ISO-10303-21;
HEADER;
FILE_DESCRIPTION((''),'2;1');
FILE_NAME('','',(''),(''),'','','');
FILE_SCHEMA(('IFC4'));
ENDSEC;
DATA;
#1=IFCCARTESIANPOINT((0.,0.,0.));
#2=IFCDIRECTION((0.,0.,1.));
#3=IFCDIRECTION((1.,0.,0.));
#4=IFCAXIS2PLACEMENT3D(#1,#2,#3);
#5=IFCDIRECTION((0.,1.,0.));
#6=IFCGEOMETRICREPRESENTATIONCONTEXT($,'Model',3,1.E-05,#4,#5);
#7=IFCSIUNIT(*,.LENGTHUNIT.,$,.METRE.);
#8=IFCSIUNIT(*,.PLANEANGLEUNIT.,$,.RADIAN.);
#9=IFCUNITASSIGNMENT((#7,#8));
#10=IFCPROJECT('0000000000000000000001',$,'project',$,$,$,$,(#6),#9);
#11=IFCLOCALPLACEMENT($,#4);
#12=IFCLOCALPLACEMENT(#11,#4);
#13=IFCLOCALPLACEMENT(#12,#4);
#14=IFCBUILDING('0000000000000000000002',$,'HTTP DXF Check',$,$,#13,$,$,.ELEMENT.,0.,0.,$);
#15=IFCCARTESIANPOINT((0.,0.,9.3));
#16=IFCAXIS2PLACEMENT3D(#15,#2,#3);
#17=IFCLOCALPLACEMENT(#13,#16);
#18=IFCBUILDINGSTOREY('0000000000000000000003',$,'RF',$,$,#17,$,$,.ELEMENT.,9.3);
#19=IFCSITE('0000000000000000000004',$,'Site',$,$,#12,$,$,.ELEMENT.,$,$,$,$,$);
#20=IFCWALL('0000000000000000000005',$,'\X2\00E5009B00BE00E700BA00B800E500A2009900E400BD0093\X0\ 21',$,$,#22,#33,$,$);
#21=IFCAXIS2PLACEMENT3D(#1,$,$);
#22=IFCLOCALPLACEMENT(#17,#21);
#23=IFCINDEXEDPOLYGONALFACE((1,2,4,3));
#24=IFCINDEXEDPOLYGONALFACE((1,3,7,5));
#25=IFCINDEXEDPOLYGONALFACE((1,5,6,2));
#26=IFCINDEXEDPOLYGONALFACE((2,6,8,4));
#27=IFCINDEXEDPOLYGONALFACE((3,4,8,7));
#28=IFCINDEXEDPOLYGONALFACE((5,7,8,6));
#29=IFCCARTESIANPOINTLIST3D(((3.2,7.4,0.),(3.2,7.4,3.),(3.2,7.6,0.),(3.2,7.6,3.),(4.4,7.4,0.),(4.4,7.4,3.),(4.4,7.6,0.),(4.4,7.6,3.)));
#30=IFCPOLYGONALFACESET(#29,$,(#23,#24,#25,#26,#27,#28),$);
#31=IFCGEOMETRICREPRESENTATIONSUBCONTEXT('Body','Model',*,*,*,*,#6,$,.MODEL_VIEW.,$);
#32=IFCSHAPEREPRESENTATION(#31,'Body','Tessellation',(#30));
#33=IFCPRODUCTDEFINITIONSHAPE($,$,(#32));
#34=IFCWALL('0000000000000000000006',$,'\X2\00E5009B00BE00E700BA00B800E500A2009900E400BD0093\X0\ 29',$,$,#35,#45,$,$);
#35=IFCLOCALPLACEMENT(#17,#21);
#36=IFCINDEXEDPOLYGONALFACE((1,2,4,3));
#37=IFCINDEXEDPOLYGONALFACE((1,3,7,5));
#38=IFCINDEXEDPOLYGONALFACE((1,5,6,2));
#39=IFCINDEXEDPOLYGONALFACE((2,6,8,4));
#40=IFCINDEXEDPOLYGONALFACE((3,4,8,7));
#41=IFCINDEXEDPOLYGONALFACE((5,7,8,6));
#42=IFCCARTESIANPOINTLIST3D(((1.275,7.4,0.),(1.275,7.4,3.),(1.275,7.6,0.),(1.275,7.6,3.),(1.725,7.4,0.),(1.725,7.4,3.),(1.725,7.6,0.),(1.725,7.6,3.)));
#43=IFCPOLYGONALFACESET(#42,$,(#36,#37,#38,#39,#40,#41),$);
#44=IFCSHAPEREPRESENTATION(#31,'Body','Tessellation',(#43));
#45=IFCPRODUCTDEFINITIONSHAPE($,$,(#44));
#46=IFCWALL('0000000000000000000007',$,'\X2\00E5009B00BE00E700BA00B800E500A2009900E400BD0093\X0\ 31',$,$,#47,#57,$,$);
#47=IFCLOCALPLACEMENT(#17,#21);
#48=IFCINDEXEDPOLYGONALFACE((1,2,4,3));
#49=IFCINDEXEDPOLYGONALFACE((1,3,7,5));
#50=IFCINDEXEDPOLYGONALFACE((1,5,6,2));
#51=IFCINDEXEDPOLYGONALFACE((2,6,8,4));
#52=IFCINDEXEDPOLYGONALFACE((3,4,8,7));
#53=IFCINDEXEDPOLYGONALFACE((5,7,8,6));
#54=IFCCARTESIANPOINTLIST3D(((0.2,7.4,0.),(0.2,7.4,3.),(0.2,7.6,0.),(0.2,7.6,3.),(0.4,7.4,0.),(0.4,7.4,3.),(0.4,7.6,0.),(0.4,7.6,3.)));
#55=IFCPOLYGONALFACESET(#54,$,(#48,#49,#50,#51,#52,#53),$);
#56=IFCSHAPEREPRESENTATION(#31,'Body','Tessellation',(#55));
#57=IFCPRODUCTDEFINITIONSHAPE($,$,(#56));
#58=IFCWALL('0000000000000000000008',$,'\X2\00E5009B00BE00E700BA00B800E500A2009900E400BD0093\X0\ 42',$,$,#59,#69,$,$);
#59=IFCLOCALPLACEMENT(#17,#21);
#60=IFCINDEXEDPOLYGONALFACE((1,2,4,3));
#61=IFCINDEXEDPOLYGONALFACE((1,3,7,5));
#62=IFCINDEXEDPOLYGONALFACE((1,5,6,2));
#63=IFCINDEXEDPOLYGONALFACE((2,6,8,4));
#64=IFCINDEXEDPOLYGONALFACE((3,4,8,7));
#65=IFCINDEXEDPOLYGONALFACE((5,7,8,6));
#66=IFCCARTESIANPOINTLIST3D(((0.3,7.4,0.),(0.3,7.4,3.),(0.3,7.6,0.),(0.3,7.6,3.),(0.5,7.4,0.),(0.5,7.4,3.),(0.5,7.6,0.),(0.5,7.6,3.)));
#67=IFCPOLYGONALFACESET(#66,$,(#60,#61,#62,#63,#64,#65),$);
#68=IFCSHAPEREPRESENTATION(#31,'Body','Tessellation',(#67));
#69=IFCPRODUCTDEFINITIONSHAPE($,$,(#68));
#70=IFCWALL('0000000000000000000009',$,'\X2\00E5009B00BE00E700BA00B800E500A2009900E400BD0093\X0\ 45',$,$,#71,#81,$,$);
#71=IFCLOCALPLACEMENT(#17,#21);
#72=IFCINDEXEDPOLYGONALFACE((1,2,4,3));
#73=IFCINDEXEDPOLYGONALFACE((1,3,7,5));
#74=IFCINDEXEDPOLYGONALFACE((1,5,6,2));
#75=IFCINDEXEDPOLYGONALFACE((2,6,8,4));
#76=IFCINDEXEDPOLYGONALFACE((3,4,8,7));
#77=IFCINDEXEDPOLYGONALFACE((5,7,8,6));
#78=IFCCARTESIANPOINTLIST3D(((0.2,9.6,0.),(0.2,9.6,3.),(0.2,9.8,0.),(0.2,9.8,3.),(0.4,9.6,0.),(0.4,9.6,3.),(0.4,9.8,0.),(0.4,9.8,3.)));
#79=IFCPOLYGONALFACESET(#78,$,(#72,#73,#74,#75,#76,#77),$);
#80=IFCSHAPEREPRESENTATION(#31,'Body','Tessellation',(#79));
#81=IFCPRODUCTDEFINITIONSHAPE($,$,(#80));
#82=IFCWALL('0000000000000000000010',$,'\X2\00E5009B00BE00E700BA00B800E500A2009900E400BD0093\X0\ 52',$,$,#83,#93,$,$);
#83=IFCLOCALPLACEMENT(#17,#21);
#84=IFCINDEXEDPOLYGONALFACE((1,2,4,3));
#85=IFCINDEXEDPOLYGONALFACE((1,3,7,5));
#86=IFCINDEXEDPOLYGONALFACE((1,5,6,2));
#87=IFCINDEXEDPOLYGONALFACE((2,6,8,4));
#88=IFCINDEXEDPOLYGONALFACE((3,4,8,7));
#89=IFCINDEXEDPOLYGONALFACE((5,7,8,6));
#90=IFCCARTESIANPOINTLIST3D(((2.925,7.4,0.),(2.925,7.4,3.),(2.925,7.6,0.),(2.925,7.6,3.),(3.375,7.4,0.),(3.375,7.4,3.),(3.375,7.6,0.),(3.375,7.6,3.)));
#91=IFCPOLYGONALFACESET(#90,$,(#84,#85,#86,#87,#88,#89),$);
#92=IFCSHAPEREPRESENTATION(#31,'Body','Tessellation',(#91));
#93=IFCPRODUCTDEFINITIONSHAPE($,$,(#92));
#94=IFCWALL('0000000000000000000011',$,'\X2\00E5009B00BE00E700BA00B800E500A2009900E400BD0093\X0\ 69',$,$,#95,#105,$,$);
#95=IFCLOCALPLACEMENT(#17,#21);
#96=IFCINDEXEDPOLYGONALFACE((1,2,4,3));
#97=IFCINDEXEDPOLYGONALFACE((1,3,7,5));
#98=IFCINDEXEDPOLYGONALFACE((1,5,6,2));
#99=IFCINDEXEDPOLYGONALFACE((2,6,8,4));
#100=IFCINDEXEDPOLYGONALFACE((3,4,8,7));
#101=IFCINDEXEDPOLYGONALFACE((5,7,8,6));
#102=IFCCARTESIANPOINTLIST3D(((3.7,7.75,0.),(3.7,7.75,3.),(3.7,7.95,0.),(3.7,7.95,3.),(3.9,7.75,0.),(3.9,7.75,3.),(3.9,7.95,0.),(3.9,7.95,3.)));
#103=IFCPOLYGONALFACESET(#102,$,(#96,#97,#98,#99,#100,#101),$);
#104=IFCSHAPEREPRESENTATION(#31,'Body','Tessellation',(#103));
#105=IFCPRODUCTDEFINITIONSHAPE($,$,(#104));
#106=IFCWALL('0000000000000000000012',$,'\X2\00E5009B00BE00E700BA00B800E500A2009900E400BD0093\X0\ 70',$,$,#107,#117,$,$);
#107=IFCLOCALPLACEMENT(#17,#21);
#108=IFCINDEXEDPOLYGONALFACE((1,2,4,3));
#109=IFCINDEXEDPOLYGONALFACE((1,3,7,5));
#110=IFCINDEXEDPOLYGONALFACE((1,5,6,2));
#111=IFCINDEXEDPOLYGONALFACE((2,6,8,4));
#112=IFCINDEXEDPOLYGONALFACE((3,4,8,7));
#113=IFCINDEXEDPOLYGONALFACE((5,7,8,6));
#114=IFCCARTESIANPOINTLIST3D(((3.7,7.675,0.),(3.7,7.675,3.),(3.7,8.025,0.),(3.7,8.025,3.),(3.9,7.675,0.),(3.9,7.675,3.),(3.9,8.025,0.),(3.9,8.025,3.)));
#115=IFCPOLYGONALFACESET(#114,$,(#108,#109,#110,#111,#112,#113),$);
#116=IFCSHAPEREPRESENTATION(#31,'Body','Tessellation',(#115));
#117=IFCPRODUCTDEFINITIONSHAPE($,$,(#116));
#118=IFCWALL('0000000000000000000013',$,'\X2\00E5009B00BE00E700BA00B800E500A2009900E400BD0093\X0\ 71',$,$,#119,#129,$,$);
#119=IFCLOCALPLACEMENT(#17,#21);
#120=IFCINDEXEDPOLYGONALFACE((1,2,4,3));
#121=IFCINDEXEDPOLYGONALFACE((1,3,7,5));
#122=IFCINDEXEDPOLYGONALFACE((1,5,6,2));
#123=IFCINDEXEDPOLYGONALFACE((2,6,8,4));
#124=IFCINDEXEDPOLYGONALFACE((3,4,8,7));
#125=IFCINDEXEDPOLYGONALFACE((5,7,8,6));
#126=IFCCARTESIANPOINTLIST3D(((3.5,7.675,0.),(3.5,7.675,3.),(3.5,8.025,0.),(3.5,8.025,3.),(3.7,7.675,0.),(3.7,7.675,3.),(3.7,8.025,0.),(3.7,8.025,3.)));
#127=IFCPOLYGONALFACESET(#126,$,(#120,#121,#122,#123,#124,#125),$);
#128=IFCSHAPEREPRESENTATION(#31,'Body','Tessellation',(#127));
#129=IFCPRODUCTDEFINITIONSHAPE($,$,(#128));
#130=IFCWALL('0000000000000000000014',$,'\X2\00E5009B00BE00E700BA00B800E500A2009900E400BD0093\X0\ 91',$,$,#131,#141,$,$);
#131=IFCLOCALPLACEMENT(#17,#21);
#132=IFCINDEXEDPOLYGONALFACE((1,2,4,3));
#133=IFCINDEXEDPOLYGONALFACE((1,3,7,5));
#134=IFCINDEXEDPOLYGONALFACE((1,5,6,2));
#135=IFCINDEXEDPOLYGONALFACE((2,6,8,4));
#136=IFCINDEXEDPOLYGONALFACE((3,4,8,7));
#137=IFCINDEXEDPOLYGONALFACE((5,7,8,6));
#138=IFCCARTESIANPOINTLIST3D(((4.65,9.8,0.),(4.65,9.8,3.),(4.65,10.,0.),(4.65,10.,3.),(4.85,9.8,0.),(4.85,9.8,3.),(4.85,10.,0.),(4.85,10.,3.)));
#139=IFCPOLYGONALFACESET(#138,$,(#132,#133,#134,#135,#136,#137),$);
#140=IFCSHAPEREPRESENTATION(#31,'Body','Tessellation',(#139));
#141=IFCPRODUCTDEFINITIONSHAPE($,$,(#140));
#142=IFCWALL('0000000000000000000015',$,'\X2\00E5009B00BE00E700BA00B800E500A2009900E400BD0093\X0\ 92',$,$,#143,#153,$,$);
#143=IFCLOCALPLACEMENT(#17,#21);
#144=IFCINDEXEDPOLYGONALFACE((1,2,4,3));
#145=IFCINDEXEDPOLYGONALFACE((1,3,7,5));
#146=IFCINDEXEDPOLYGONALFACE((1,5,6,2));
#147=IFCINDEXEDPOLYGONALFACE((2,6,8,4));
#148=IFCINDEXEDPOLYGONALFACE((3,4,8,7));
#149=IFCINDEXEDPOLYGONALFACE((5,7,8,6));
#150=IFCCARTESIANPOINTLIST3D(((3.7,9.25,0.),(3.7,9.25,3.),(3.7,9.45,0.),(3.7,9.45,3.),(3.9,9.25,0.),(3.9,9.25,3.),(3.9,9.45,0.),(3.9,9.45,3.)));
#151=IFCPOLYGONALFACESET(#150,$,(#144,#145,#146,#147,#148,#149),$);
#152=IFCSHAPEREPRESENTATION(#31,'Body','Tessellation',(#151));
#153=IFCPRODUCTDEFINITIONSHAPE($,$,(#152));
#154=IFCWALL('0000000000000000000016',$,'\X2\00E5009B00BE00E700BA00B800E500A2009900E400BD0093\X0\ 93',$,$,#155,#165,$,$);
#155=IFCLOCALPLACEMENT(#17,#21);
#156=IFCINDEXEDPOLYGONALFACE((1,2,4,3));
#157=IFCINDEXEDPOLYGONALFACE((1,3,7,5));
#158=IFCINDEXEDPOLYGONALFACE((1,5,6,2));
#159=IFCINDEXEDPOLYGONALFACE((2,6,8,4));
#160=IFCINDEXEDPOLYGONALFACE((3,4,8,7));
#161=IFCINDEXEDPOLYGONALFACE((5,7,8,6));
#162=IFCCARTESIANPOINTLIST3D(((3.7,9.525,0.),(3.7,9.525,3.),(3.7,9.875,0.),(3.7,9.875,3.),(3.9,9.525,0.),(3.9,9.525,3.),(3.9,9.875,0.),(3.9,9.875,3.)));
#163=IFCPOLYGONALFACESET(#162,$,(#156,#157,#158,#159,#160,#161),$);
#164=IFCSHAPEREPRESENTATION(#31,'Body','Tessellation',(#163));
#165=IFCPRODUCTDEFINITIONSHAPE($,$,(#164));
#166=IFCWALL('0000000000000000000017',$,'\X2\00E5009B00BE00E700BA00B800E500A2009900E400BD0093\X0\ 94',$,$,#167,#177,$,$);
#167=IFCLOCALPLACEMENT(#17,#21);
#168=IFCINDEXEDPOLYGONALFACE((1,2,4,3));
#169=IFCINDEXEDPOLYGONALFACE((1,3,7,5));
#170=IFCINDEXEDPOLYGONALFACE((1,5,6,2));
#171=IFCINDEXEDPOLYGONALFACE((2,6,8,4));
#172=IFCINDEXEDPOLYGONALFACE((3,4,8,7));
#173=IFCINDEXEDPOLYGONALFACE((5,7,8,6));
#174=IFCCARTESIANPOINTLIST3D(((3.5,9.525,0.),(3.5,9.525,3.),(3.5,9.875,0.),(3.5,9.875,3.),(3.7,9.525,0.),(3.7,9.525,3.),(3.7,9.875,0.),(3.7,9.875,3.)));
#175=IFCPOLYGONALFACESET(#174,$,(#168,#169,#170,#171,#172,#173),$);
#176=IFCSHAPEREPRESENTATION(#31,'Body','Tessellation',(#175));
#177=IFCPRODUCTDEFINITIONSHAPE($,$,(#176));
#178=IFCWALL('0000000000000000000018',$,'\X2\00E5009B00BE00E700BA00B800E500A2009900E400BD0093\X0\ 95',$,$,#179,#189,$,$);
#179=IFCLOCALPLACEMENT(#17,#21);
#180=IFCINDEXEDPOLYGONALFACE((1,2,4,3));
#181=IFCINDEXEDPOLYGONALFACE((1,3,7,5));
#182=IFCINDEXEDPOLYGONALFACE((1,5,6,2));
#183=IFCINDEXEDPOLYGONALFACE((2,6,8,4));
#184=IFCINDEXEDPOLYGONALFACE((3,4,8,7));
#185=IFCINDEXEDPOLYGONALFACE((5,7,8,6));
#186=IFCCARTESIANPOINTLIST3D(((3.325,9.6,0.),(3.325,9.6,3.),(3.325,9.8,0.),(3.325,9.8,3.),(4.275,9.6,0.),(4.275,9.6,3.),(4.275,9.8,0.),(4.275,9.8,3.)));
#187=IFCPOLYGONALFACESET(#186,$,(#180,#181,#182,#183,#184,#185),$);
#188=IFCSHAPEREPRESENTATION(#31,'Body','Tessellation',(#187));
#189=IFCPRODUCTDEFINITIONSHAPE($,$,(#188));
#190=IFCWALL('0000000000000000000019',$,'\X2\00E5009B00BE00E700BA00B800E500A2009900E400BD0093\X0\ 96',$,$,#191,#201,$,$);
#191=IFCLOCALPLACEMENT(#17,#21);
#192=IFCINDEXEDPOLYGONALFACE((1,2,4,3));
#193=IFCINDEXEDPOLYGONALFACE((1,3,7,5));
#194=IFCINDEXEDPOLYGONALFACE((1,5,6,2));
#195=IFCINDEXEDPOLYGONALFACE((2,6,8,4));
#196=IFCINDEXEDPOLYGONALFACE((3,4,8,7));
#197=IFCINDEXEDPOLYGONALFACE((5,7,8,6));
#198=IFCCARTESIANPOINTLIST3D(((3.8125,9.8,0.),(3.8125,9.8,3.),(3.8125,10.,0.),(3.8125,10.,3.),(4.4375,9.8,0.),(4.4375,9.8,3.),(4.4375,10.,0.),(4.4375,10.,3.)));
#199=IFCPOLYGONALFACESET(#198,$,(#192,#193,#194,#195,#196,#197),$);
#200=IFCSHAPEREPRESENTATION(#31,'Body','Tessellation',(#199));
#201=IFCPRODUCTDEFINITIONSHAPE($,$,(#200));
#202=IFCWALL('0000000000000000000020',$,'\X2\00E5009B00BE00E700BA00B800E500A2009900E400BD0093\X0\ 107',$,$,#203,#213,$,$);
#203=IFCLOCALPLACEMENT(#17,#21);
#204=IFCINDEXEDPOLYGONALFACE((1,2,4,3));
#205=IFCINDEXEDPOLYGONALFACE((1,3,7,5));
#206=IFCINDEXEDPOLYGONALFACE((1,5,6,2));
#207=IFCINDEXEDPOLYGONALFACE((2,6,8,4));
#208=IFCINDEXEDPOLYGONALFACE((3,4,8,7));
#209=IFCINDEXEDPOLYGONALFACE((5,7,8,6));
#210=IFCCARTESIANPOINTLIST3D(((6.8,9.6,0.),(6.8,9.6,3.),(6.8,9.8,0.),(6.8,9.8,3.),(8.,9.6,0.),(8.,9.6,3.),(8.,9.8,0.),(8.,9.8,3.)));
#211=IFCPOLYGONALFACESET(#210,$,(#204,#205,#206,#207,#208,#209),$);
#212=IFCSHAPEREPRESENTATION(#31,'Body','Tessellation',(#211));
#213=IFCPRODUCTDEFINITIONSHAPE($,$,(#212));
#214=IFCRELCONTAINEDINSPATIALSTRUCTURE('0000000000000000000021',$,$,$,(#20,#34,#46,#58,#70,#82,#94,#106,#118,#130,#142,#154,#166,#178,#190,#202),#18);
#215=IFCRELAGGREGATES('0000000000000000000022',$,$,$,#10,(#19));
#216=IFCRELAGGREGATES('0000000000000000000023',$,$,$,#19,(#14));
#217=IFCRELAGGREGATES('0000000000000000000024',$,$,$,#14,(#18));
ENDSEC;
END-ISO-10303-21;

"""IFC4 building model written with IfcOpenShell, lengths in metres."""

from ifc_helpers import new_model, si_unit, direction, frame, frame_2d, origin_with_axes, place, context, subcontext, project, spatial, rectangle, extrude, element, save


model = new_model("IFC4")

# Units and contexts
model_context = context("Model", 3, precision=1e-05, world=origin_with_axes(), true_north=direction((0.0, 1.0, 0.0)))
body_context = subcontext(model_context, "Body", "Model", "MODEL_VIEW")
ifc_project = project(units=[si_unit("LENGTHUNIT", "METRE"), si_unit("PLANEANGLEUNIT", "RADIAN")], contexts=[model_context])

# Site, building, storey
placement = place(None, origin_with_axes())
site_placement = place(placement, origin_with_axes())
site = spatial("IfcSite", under=ifc_project, at=site_placement, Name="Site", CompositionType="ELEMENT")
building_placement = place(site_placement, origin_with_axes())
building = spatial("IfcBuilding", under=site, at=building_placement, Name="HTTP DXF Check", CompositionType="ELEMENT", ElevationOfRefHeight=0.0, ElevationOfTerrain=0.0)
storey_placement = place(building_placement, frame((0.0, 0.0, 9.3), z_axis=(0.0, 0.0, 1.0), x_axis=(1.0, 0.0, 0.0)))
storey = spatial("IfcBuildingStorey", under=building, at=storey_placement, Name="RF", CompositionType="ELEMENT", Elevation=9.3)

# Walls
wall_1_placement = place(storey_placement, frame((3.8, 7.5, 0.0), z_axis=(0.0, 0.0, 1.0), x_axis=(1.0, 0.0, 0.0)))
element("IfcWall", 1, at=wall_1_placement, inside=storey, Name="å\u009b¾çº¸å¢\u0099ä½\u0093 21", context=body_context, shape_type="SweptSolid", body=[
    extrude(rectangle(XDim=1.2, YDim=0.2, at=frame_2d((0.0, 0.0), x_axis=(1.0, 0.0, 0.0))), frame((0.0, 0.0, 0.0), z_axis=(0.0, 0.0, 1.0)), (0.0, 0.0, 1.0), 3.0),
])
wall_2_placement = place(storey_placement, frame((1.5, 7.5, 0.0), z_axis=(0.0, 0.0, 1.0), x_axis=(1.0, 0.0, 0.0)))
element("IfcWall", 2, at=wall_2_placement, inside=storey, Name="å\u009b¾çº¸å¢\u0099ä½\u0093 29", context=body_context, shape_type="SweptSolid", body=[
    extrude(rectangle(XDim=0.45, YDim=0.2, at=frame_2d((0.0, 0.0), x_axis=(1.0, 0.0, 0.0))), frame((0.0, 0.0, 0.0), z_axis=(0.0, 0.0, 1.0)), (0.0, 0.0, 1.0), 3.0),
])
for number, where, z_axis, x_axis, name in (
    (3, (0.3, 7.5, 0.0), (0.0, 0.0, 1.0), (1.0, 0.0, 0.0), "å\u009b¾çº¸å¢\u0099ä½\u0093 31"),
    (4, (0.4, 7.5, 0.0), (0.0, 0.0, 1.0), (1.0, 0.0, 0.0), "å\u009b¾çº¸å¢\u0099ä½\u0093 42"),
    (5, (0.3, 9.7, 0.0), (0.0, 0.0, 1.0), (1.0, 0.0, 0.0), "å\u009b¾çº¸å¢\u0099ä½\u0093 45"),
):
    element("IfcWall", number, at=place(storey_placement, frame(where, z_axis=z_axis, x_axis=x_axis)), inside=storey, Name=name, context=body_context, shape_type="SweptSolid", body=[
        extrude(rectangle(XDim=0.2, YDim=0.2, at=frame_2d((0.0, 0.0), x_axis=(1.0, 0.0, 0.0))), frame((0.0, 0.0, 0.0), z_axis=(0.0, 0.0, 1.0)), (0.0, 0.0, 1.0), 3.0),
    ])
wall_3_placement = place(storey_placement, frame((3.15, 7.5, 0.0), z_axis=(0.0, 0.0, 1.0), x_axis=(1.0, 0.0, 0.0)))
element("IfcWall", 6, at=wall_3_placement, inside=storey, Name="å\u009b¾çº¸å¢\u0099ä½\u0093 52", context=body_context, shape_type="SweptSolid", body=[
    extrude(rectangle(XDim=0.45, YDim=0.2, at=frame_2d((0.0, 0.0), x_axis=(1.0, 0.0, 0.0))), frame((0.0, 0.0, 0.0), z_axis=(0.0, 0.0, 1.0)), (0.0, 0.0, 1.0), 3.0),
])
wall_4_placement = place(storey_placement, frame((3.8, 7.85, 0.0), z_axis=(0.0, 0.0, 1.0), x_axis=(-1.0, 0.0, 0.0)))
element("IfcWall", 7, at=wall_4_placement, inside=storey, Name="å\u009b¾çº¸å¢\u0099ä½\u0093 69", context=body_context, shape_type="SweptSolid", body=[
    extrude(rectangle(XDim=0.2, YDim=0.2, at=frame_2d((0.0, 0.0), x_axis=(1.0, 0.0, 0.0))), frame((0.0, 0.0, 0.0), z_axis=(0.0, 0.0, 1.0)), (0.0, 0.0, 1.0), 3.0),
])
for number, where, z_axis, x_axis, name in (
    (8, (3.8, 7.85, 0.0), (0.0, 0.0, 1.0), (0.0, -1.0, 0.0), "å\u009b¾çº¸å¢\u0099ä½\u0093 70"),
    (9, (3.6, 7.85, 0.0), (0.0, 0.0, 1.0), (0.0, -1.0, 0.0), "å\u009b¾çº¸å¢\u0099ä½\u0093 71"),
):
    element("IfcWall", number, at=place(storey_placement, frame(where, z_axis=z_axis, x_axis=x_axis)), inside=storey, Name=name, context=body_context, shape_type="SweptSolid", body=[
        extrude(rectangle(XDim=0.35, YDim=0.2, at=frame_2d((0.0, 0.0), x_axis=(1.0, 0.0, 0.0))), frame((0.0, 0.0, 0.0), z_axis=(0.0, 0.0, 1.0)), (0.0, 0.0, 1.0), 3.0),
    ])
for number, where, z_axis, x_axis, name in (
    (10, (4.75, 9.9, 0.0), (0.0, 0.0, 1.0), (0.0, -1.0, 0.0), "å\u009b¾çº¸å¢\u0099ä½\u0093 91"),
    (11, (3.8, 9.35, 0.0), (0.0, 0.0, 1.0), (-1.0, 0.0, 0.0), "å\u009b¾çº¸å¢\u0099ä½\u0093 92"),
):
    element("IfcWall", number, at=place(storey_placement, frame(where, z_axis=z_axis, x_axis=x_axis)), inside=storey, Name=name, context=body_context, shape_type="SweptSolid", body=[
        extrude(rectangle(XDim=0.2, YDim=0.2, at=frame_2d((0.0, 0.0), x_axis=(1.0, 0.0, 0.0))), frame((0.0, 0.0, 0.0), z_axis=(0.0, 0.0, 1.0)), (0.0, 0.0, 1.0), 3.0),
    ])
for number, where, z_axis, x_axis, name in (
    (12, (3.8, 9.7, 0.0), (0.0, 0.0, 1.0), (0.0, -1.0, 0.0), "å\u009b¾çº¸å¢\u0099ä½\u0093 93"),
    (13, (3.6, 9.7, 0.0), (0.0, 0.0, 1.0), (0.0, -1.0, 0.0), "å\u009b¾çº¸å¢\u0099ä½\u0093 94"),
):
    element("IfcWall", number, at=place(storey_placement, frame(where, z_axis=z_axis, x_axis=x_axis)), inside=storey, Name=name, context=body_context, shape_type="SweptSolid", body=[
        extrude(rectangle(XDim=0.35, YDim=0.2, at=frame_2d((0.0, 0.0), x_axis=(1.0, 0.0, 0.0))), frame((0.0, 0.0, 0.0), z_axis=(0.0, 0.0, 1.0)), (0.0, 0.0, 1.0), 3.0),
    ])
wall_5_placement = place(storey_placement, frame((3.8, 9.7, 0.0), z_axis=(0.0, 0.0, 1.0), x_axis=(1.0, 0.0, 0.0)))
element("IfcWall", 14, at=wall_5_placement, inside=storey, Name="å\u009b¾çº¸å¢\u0099ä½\u0093 95", context=body_context, shape_type="SweptSolid", body=[
    extrude(rectangle(XDim=0.95, YDim=0.2, at=frame_2d((0.0, 0.0), x_axis=(1.0, 0.0, 0.0))), frame((0.0, 0.0, 0.0), z_axis=(0.0, 0.0, 1.0)), (0.0, 0.0, 1.0), 3.0),
])
wall_6_placement = place(storey_placement, frame((4.125, 9.9, 0.0), z_axis=(0.0, 0.0, 1.0), x_axis=(1.0, 0.0, 0.0)))
element("IfcWall", 15, at=wall_6_placement, inside=storey, Name="å\u009b¾çº¸å¢\u0099ä½\u0093 96", context=body_context, shape_type="SweptSolid", body=[
    extrude(rectangle(XDim=0.625, YDim=0.2, at=frame_2d((0.0, 0.0), x_axis=(1.0, 0.0, 0.0))), frame((0.0, 0.0, 0.0), z_axis=(0.0, 0.0, 1.0)), (0.0, 0.0, 1.0), 3.0),
])
wall_7_placement = place(storey_placement, frame((7.4, 9.7, 0.0), z_axis=(0.0, 0.0, 1.0), x_axis=(1.0, 0.0, 0.0)))
element("IfcWall", 16, at=wall_7_placement, inside=storey, Name="å\u009b¾çº¸å¢\u0099ä½\u0093 107", context=body_context, shape_type="SweptSolid", body=[
    extrude(rectangle(XDim=1.2, YDim=0.2, at=frame_2d((0.0, 0.0), x_axis=(1.0, 0.0, 0.0))), frame((0.0, 0.0, 0.0), z_axis=(0.0, 0.0, 1.0)), (0.0, 0.0, 1.0), 3.0),
])

save(model, "model.ifc")
